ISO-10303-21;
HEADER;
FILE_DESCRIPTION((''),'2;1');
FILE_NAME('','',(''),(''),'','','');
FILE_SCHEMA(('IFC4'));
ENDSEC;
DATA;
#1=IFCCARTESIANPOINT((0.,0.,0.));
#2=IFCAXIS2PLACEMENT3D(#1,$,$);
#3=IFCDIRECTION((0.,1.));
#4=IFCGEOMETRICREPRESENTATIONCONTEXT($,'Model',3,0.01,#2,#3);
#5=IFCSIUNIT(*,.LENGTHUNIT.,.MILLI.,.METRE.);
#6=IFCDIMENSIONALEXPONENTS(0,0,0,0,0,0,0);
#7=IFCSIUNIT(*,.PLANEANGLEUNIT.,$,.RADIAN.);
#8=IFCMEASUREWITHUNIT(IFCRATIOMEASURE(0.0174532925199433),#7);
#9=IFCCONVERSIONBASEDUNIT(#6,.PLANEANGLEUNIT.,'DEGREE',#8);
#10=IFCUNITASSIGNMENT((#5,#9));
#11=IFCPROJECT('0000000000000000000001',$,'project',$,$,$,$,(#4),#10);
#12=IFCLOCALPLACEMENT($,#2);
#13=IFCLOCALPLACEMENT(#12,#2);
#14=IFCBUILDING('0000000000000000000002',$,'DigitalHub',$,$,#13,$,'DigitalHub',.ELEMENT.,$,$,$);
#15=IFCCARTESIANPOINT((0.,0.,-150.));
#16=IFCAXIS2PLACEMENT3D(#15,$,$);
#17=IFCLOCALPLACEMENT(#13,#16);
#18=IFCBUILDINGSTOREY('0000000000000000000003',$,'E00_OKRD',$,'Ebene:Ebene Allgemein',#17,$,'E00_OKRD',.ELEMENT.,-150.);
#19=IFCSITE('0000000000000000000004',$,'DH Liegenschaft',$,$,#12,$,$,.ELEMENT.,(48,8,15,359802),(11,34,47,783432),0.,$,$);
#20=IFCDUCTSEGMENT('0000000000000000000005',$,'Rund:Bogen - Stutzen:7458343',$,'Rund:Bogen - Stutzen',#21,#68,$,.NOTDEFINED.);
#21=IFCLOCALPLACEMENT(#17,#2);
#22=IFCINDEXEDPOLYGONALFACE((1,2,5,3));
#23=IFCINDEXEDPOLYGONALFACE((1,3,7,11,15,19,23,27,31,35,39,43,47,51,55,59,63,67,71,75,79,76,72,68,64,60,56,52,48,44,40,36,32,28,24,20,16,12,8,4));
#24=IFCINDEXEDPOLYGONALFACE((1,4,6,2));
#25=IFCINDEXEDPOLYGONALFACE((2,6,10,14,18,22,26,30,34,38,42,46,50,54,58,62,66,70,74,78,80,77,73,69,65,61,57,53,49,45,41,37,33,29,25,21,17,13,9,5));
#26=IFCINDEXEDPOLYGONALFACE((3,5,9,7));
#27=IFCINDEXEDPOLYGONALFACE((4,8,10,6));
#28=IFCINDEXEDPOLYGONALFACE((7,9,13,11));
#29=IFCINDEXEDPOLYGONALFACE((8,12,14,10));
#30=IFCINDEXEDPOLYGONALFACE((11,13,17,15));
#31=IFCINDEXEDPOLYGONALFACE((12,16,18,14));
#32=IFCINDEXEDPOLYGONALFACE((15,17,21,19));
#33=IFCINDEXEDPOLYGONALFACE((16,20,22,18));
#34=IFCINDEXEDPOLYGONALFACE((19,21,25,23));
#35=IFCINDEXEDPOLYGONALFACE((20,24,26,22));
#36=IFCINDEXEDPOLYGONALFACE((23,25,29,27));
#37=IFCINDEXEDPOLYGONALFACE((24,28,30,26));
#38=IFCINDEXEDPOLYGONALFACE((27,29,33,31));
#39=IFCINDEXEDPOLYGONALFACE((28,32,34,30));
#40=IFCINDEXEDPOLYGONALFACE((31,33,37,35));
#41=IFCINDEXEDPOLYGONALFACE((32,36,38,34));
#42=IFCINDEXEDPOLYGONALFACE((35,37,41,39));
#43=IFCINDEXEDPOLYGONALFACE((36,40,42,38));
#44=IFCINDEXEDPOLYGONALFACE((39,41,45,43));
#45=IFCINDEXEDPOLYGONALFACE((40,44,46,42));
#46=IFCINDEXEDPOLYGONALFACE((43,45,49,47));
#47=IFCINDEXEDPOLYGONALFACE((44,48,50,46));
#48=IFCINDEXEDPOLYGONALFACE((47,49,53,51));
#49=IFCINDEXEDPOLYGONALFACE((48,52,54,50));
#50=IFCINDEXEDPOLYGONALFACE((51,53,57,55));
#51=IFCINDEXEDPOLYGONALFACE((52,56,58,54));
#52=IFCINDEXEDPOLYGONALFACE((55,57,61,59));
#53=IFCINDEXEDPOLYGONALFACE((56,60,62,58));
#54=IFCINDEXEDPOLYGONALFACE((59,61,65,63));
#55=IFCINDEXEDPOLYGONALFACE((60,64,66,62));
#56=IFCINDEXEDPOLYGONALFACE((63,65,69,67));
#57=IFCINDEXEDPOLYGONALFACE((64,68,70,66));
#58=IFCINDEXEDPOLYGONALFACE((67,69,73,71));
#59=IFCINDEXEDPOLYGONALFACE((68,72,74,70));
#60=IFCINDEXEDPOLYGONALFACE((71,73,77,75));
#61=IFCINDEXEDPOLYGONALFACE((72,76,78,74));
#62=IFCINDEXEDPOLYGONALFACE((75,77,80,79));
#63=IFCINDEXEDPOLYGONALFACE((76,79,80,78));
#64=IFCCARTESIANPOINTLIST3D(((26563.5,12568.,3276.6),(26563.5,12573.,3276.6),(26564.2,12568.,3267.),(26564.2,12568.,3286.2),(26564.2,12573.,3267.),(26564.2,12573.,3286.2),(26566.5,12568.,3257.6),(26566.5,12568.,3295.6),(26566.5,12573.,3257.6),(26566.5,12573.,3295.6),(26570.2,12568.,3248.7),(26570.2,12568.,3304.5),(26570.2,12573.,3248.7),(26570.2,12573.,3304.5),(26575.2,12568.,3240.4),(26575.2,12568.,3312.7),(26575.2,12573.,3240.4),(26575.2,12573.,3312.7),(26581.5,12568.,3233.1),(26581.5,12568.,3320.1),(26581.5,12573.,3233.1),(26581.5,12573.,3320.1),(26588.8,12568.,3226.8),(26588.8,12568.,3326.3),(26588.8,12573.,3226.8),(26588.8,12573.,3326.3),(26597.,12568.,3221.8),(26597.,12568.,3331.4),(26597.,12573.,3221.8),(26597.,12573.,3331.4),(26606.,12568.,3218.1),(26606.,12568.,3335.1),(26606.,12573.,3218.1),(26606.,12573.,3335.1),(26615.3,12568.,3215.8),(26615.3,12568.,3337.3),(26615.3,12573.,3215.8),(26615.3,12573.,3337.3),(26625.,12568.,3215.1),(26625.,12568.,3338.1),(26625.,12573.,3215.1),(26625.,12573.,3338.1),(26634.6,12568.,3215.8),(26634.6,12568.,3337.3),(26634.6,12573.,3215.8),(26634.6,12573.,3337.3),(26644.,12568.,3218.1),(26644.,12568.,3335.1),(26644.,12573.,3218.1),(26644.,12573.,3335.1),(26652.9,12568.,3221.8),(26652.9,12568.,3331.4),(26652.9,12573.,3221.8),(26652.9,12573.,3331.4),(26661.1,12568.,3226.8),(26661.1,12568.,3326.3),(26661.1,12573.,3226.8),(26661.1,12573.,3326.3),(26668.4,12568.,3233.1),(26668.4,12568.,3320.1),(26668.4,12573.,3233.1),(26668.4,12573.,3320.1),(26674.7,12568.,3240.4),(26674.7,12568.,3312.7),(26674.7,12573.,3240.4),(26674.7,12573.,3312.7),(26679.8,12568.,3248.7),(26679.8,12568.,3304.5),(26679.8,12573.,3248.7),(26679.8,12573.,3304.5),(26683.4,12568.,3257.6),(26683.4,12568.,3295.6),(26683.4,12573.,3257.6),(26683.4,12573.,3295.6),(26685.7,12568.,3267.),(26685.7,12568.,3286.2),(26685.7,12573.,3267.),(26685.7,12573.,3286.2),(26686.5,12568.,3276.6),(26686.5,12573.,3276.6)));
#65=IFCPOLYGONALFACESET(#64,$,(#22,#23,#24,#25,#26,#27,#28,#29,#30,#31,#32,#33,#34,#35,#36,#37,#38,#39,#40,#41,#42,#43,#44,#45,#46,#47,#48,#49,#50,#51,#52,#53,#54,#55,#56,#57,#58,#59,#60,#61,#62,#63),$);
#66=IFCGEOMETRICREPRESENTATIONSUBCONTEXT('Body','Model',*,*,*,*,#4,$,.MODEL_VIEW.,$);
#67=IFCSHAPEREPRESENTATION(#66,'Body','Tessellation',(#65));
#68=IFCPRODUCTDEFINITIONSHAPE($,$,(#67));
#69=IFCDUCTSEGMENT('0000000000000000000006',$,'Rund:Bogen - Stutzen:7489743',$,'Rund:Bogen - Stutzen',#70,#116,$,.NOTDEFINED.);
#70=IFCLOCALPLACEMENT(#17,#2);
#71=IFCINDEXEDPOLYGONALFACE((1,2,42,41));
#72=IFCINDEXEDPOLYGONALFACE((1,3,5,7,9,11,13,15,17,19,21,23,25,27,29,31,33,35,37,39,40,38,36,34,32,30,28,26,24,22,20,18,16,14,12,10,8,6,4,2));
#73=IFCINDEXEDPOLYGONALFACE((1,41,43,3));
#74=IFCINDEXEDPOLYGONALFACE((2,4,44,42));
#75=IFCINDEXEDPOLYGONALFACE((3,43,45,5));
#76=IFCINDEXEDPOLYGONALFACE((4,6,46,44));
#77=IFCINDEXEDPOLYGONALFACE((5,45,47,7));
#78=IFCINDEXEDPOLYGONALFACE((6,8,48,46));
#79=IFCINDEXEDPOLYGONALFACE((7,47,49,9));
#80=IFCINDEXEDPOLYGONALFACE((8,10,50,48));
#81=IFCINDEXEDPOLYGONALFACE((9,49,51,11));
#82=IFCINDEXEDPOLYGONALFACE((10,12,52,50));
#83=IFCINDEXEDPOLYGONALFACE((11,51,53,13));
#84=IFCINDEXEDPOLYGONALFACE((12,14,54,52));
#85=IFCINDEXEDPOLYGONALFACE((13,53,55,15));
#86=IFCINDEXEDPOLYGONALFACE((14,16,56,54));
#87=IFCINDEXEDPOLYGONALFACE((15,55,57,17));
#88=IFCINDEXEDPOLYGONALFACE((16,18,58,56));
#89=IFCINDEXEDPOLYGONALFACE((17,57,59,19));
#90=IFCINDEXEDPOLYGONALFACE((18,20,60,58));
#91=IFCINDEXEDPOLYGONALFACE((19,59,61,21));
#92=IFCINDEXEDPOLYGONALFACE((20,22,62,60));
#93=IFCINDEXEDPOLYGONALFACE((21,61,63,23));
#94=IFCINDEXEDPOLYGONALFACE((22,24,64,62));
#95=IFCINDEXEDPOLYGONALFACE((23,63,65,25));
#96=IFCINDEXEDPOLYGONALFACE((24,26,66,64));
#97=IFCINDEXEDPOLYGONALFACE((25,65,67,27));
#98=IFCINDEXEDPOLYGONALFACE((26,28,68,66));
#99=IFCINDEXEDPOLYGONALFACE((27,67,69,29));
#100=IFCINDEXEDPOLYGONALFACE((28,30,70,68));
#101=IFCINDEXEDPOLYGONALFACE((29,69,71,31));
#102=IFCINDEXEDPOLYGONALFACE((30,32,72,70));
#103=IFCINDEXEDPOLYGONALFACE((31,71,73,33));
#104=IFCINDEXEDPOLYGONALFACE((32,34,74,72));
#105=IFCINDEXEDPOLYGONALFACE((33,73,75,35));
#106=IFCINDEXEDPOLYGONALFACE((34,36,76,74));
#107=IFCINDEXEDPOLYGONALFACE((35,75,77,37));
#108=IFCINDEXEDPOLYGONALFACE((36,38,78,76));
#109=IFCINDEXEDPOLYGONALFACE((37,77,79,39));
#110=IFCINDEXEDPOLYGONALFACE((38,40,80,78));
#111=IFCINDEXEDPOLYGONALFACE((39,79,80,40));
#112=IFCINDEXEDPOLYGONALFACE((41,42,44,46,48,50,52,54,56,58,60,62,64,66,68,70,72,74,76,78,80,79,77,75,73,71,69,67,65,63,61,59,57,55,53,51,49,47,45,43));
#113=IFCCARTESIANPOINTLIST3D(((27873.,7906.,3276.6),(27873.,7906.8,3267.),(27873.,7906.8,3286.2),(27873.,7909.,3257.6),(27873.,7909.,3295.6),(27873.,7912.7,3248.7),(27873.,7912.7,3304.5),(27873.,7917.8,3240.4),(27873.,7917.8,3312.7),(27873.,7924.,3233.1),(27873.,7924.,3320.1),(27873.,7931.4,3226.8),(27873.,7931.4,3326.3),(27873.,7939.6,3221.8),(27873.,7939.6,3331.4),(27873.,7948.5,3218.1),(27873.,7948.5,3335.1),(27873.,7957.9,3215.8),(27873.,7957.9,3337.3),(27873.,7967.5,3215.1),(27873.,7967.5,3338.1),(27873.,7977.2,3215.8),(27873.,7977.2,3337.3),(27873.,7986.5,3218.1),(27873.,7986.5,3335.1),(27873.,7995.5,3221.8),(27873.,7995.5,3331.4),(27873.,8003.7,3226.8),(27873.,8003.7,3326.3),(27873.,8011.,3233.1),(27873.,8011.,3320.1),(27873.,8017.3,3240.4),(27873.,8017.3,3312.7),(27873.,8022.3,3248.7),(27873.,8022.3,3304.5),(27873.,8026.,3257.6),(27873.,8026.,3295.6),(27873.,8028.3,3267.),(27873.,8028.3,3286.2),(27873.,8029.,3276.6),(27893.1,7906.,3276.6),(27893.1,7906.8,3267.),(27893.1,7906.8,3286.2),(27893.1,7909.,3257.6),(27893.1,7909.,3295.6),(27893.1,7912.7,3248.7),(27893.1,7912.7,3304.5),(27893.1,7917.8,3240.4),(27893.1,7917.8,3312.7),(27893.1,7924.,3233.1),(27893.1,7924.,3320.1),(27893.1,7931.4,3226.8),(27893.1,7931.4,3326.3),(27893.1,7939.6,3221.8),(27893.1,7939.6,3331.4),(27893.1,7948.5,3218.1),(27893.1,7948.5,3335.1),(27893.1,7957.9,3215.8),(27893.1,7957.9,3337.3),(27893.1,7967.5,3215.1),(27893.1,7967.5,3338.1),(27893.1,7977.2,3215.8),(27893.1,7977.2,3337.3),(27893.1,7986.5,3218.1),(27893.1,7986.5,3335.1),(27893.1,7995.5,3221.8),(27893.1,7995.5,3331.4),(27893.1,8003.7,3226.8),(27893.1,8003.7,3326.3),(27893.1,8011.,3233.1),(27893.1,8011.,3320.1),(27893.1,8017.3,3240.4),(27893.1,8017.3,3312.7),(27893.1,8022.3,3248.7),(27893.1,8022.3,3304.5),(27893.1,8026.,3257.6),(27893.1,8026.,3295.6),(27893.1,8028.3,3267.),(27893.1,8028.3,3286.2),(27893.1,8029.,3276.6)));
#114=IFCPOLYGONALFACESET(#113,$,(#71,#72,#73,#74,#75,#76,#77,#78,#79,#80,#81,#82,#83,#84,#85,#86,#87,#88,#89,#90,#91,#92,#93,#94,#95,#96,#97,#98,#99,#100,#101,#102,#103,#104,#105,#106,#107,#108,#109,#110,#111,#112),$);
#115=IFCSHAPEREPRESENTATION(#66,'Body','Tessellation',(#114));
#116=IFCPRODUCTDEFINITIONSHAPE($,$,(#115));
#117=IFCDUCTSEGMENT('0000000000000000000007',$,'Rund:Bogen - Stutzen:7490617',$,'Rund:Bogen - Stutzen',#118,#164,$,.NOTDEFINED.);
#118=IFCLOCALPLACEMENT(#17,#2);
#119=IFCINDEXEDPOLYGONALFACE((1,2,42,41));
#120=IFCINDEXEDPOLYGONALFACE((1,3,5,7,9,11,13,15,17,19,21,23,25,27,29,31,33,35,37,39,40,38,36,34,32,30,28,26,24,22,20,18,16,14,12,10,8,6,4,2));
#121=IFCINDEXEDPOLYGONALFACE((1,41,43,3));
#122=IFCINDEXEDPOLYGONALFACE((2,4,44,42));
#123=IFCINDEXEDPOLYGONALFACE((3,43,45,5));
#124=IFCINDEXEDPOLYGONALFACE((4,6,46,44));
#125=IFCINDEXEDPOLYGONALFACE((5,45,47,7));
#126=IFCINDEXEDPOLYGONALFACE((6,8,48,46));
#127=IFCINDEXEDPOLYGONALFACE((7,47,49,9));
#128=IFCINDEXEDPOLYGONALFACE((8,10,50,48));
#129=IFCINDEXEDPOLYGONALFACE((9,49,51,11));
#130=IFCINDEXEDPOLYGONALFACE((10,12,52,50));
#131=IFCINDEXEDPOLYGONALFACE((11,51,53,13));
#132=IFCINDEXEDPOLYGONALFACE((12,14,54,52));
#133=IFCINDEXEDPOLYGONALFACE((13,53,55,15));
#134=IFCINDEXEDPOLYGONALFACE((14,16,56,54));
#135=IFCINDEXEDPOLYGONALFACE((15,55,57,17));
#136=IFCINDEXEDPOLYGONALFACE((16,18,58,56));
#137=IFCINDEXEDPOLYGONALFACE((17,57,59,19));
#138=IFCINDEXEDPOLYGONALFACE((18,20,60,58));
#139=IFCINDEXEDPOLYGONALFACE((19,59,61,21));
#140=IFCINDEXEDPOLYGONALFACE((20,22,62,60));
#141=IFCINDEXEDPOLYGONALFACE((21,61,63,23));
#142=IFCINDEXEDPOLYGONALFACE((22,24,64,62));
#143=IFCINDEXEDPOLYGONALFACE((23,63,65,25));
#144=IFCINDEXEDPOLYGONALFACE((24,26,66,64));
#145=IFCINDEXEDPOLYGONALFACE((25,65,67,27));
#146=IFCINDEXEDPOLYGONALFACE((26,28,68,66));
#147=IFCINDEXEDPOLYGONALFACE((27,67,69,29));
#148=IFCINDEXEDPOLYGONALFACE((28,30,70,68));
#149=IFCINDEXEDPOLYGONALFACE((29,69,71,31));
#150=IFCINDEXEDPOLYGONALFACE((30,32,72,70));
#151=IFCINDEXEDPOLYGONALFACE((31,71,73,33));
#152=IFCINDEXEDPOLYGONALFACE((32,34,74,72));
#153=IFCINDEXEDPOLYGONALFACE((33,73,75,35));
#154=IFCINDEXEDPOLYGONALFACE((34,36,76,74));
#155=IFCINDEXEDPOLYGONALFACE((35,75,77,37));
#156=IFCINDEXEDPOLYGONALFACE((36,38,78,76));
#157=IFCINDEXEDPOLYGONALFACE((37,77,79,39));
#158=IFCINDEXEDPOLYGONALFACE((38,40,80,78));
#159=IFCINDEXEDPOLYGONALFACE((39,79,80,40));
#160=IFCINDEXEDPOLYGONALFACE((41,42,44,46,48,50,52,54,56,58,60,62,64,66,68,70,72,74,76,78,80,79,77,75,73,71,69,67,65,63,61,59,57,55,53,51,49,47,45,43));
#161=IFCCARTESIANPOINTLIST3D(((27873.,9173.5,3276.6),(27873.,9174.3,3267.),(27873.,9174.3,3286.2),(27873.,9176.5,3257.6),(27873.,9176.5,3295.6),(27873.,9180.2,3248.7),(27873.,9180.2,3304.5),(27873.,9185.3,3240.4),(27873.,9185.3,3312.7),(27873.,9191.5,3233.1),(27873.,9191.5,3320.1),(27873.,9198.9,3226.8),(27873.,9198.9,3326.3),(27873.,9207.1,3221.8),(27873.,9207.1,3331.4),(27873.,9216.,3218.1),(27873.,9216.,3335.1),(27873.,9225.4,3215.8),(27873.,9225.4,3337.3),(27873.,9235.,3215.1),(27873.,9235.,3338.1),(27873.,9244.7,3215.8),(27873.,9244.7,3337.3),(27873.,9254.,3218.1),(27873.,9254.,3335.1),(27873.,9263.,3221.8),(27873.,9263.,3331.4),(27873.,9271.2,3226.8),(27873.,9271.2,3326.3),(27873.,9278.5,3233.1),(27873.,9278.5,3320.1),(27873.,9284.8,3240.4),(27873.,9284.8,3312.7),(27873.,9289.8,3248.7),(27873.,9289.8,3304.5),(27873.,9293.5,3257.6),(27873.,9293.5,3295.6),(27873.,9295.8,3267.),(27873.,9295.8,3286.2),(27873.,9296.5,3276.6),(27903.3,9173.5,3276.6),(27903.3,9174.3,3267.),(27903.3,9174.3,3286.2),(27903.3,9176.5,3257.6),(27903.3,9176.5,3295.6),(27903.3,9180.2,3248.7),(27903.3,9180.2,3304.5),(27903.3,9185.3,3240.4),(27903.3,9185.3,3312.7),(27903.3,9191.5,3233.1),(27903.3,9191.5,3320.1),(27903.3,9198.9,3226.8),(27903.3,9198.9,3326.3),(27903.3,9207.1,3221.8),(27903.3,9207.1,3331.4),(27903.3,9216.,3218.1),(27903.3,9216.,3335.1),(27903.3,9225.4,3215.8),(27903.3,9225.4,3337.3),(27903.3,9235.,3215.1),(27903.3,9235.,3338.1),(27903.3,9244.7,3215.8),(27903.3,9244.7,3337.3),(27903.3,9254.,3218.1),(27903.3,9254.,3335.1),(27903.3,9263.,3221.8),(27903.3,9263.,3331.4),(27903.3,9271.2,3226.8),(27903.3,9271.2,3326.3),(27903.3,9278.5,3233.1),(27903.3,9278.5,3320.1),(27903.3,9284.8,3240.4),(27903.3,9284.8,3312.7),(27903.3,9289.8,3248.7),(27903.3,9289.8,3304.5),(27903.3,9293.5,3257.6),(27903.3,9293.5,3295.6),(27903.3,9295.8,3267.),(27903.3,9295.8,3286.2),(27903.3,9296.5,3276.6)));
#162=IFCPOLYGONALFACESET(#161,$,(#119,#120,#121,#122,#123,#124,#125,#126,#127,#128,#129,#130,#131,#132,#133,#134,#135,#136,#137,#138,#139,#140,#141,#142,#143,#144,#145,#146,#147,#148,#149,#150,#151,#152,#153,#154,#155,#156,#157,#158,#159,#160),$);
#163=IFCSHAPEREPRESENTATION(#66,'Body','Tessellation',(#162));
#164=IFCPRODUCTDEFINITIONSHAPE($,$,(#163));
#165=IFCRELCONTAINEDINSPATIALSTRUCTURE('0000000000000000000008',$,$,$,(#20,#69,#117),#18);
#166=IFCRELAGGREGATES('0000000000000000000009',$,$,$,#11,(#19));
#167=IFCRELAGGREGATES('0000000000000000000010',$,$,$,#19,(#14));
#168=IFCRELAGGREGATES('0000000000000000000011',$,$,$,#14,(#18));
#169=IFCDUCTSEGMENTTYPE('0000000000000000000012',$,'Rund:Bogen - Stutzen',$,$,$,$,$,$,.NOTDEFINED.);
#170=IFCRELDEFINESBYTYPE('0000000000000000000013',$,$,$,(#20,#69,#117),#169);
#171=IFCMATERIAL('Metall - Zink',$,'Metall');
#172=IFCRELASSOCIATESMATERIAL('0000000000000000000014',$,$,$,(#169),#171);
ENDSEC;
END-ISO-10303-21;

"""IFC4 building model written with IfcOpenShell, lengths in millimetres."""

from ifc_helpers import new_model, entity, si_unit, converted_unit, direction, frame, origin, place, context, subcontext, project, spatial, indexed_curve, outline, extrude, material, type_object, element, save


model = new_model("IFC4")

# Units and contexts
model_context = context("Model", 3, precision=0.01, world=origin(), true_north=direction((0.0, 1.0)))
body_context = subcontext(model_context, "Body", "Model", "MODEL_VIEW")
ifc_project = project(units=[si_unit("LENGTHUNIT", "METRE", prefix="MILLI"), converted_unit("PLANEANGLEUNIT", "DEGREE", entity("IfcRatioMeasure", 0.0174532925199433), si_unit("PLANEANGLEUNIT", "RADIAN"), dimensions=[0, 0, 0, 0, 0, 0, 0])], contexts=[model_context])

# Site, building, storey
site_placement = place(None, origin())
site = spatial("IfcSite", under=ifc_project, at=site_placement, Name="DH Liegenschaft", CompositionType="ELEMENT", RefLatitude=(48, 8, 15, 359802), RefLongitude=(11, 34, 47, 783432), RefElevation=0.0)
building_placement = place(site_placement, origin())
building = spatial("IfcBuilding", under=site, at=building_placement, Name="DigitalHub", LongName="DigitalHub", CompositionType="ELEMENT")
storey_placement = place(building_placement, frame((0.0, 0.0, -150.0)))
storey = spatial("IfcBuildingStorey", under=building, at=storey_placement, Name="E00_OKRD", ObjectType="Ebene:Ebene Allgemein", LongName="E00_OKRD", CompositionType="ELEMENT", Elevation=-150.0)

# Duct segments
ifc_material_1 = material(Name="Metall - Zink", Category="Metall")
duct_segment_type_1 = type_object("IfcDuctSegmentType", Name="Rund:Bogen - Stutzen", PredefinedType="NOTDEFINED", material=ifc_material_1)
duct_segment_1_placement = place(storey_placement, frame((26561.9, 12568.0, 3213.5)))
element("IfcDuctSegment", 1, at=duct_segment_1_placement, inside=storey, type_object=duct_segment_type_1, Name="Rund:Bogen - Stutzen:7458343", ObjectType="Rund:Bogen - Stutzen", PredefinedType="NOTDEFINED", context=body_context, shape_type="SweptSolid", body=[
    extrude(outline(indexed_curve([(61.5, 0.0), (60.7, 9.6), (58.5, 19.0), (54.8, 27.9), (49.8, 36.1), (43.5, 43.5), (36.1, 49.8), (27.9, 54.8), (19.0, 58.5), (9.6, 60.7), (0.0, 61.5), (-9.6, 60.7), (-19.0, 58.5), (-27.9, 54.8), (-36.1, 49.8), (-43.5, 43.5), (-49.8, 36.1), (-54.8, 27.9), (-58.5, 19.0), (-60.7, 9.6), (-61.5, 0.0), (-60.7, -9.6), (-58.5, -19.0), (-54.8, -27.9), (-49.8, -36.1), (-43.5, -43.5), (-36.1, -49.8), (-27.9, -54.8), (-19.0, -58.5), (-9.6, -60.7), (0.0, -61.5), (9.6, -60.7), (19.0, -58.5), (27.9, -54.8), (36.1, -49.8), (43.5, -43.5), (49.8, -36.1), (54.8, -27.9), (58.5, -19.0), (60.7, -9.6), (61.5, 0.0)], self_intersect=False)), frame((63.1, 0.0, 63.1), z_axis=(0.0, 1.0, 0.0), x_axis=(1.0, 0.0, 0.0)), (0.0, 0.0, 1.0), 5.0),
])
duct_segment_2_placement = place(storey_placement, frame((27873.0, 7904.4, 3213.5)))
element("IfcDuctSegment", 2, at=duct_segment_2_placement, inside=storey, type_object=duct_segment_type_1, Name="Rund:Bogen - Stutzen:7489743", ObjectType="Rund:Bogen - Stutzen", PredefinedType="NOTDEFINED", context=body_context, shape_type="SweptSolid", body=[
    extrude(outline(indexed_curve([(61.5, 0.0), (60.7, 9.6), (58.5, 19.0), (54.8, 27.9), (49.8, 36.1), (43.5, 43.5), (36.1, 49.8), (27.9, 54.8), (19.0, 58.5), (9.6, 60.7), (0.0, 61.5), (-9.6, 60.7), (-19.0, 58.5), (-27.9, 54.8), (-36.1, 49.8), (-43.5, 43.5), (-49.8, 36.1), (-54.8, 27.9), (-58.5, 19.0), (-60.7, 9.6), (-61.5, 0.0), (-60.7, -9.6), (-58.5, -19.0), (-54.8, -27.9), (-49.8, -36.1), (-43.5, -43.5), (-36.1, -49.8), (-27.9, -54.8), (-19.0, -58.5), (-9.6, -60.7), (0.0, -61.5), (9.6, -60.7), (19.0, -58.5), (27.9, -54.8), (36.1, -49.8), (43.5, -43.5), (49.8, -36.1), (54.8, -27.9), (58.5, -19.0), (60.7, -9.6), (61.5, 0.0)], self_intersect=False)), frame((0.0, 63.1, 63.1), z_axis=(1.0, 0.0, 0.0), x_axis=(0.0, -1.0, 0.0)), (0.0, 0.0, 1.0), 20.2),
])
duct_segment_3_placement = place(storey_placement, frame((27873.0, 9171.9, 3213.5)))
element("IfcDuctSegment", 3, at=duct_segment_3_placement, inside=storey, type_object=duct_segment_type_1, Name="Rund:Bogen - Stutzen:7490617", ObjectType="Rund:Bogen - Stutzen", PredefinedType="NOTDEFINED", context=body_context, shape_type="SweptSolid", body=[
    extrude(outline(indexed_curve([(61.5, 0.0), (60.7, 9.6), (58.5, 19.0), (54.8, 27.9), (49.8, 36.1), (43.5, 43.5), (36.1, 49.8), (27.9, 54.8), (19.0, 58.5), (9.6, 60.7), (0.0, 61.5), (-9.6, 60.7), (-19.0, 58.5), (-27.9, 54.8), (-36.1, 49.8), (-43.5, 43.5), (-49.8, 36.1), (-54.8, 27.9), (-58.5, 19.0), (-60.7, 9.6), (-61.5, 0.0), (-60.7, -9.6), (-58.5, -19.0), (-54.8, -27.9), (-49.8, -36.1), (-43.5, -43.5), (-36.1, -49.8), (-27.9, -54.8), (-19.0, -58.5), (-9.6, -60.7), (0.0, -61.5), (9.6, -60.7), (19.0, -58.5), (27.9, -54.8), (36.1, -49.8), (43.5, -43.5), (49.8, -36.1), (54.8, -27.9), (58.5, -19.0), (60.7, -9.6), (61.5, 0.0)], self_intersect=False)), frame((0.0, 63.1, 63.1), z_axis=(1.0, 0.0, 0.0), x_axis=(0.0, -1.0, 0.0)), (0.0, 0.0, 1.0), 30.4),
])

save(model, "model.ifc")
